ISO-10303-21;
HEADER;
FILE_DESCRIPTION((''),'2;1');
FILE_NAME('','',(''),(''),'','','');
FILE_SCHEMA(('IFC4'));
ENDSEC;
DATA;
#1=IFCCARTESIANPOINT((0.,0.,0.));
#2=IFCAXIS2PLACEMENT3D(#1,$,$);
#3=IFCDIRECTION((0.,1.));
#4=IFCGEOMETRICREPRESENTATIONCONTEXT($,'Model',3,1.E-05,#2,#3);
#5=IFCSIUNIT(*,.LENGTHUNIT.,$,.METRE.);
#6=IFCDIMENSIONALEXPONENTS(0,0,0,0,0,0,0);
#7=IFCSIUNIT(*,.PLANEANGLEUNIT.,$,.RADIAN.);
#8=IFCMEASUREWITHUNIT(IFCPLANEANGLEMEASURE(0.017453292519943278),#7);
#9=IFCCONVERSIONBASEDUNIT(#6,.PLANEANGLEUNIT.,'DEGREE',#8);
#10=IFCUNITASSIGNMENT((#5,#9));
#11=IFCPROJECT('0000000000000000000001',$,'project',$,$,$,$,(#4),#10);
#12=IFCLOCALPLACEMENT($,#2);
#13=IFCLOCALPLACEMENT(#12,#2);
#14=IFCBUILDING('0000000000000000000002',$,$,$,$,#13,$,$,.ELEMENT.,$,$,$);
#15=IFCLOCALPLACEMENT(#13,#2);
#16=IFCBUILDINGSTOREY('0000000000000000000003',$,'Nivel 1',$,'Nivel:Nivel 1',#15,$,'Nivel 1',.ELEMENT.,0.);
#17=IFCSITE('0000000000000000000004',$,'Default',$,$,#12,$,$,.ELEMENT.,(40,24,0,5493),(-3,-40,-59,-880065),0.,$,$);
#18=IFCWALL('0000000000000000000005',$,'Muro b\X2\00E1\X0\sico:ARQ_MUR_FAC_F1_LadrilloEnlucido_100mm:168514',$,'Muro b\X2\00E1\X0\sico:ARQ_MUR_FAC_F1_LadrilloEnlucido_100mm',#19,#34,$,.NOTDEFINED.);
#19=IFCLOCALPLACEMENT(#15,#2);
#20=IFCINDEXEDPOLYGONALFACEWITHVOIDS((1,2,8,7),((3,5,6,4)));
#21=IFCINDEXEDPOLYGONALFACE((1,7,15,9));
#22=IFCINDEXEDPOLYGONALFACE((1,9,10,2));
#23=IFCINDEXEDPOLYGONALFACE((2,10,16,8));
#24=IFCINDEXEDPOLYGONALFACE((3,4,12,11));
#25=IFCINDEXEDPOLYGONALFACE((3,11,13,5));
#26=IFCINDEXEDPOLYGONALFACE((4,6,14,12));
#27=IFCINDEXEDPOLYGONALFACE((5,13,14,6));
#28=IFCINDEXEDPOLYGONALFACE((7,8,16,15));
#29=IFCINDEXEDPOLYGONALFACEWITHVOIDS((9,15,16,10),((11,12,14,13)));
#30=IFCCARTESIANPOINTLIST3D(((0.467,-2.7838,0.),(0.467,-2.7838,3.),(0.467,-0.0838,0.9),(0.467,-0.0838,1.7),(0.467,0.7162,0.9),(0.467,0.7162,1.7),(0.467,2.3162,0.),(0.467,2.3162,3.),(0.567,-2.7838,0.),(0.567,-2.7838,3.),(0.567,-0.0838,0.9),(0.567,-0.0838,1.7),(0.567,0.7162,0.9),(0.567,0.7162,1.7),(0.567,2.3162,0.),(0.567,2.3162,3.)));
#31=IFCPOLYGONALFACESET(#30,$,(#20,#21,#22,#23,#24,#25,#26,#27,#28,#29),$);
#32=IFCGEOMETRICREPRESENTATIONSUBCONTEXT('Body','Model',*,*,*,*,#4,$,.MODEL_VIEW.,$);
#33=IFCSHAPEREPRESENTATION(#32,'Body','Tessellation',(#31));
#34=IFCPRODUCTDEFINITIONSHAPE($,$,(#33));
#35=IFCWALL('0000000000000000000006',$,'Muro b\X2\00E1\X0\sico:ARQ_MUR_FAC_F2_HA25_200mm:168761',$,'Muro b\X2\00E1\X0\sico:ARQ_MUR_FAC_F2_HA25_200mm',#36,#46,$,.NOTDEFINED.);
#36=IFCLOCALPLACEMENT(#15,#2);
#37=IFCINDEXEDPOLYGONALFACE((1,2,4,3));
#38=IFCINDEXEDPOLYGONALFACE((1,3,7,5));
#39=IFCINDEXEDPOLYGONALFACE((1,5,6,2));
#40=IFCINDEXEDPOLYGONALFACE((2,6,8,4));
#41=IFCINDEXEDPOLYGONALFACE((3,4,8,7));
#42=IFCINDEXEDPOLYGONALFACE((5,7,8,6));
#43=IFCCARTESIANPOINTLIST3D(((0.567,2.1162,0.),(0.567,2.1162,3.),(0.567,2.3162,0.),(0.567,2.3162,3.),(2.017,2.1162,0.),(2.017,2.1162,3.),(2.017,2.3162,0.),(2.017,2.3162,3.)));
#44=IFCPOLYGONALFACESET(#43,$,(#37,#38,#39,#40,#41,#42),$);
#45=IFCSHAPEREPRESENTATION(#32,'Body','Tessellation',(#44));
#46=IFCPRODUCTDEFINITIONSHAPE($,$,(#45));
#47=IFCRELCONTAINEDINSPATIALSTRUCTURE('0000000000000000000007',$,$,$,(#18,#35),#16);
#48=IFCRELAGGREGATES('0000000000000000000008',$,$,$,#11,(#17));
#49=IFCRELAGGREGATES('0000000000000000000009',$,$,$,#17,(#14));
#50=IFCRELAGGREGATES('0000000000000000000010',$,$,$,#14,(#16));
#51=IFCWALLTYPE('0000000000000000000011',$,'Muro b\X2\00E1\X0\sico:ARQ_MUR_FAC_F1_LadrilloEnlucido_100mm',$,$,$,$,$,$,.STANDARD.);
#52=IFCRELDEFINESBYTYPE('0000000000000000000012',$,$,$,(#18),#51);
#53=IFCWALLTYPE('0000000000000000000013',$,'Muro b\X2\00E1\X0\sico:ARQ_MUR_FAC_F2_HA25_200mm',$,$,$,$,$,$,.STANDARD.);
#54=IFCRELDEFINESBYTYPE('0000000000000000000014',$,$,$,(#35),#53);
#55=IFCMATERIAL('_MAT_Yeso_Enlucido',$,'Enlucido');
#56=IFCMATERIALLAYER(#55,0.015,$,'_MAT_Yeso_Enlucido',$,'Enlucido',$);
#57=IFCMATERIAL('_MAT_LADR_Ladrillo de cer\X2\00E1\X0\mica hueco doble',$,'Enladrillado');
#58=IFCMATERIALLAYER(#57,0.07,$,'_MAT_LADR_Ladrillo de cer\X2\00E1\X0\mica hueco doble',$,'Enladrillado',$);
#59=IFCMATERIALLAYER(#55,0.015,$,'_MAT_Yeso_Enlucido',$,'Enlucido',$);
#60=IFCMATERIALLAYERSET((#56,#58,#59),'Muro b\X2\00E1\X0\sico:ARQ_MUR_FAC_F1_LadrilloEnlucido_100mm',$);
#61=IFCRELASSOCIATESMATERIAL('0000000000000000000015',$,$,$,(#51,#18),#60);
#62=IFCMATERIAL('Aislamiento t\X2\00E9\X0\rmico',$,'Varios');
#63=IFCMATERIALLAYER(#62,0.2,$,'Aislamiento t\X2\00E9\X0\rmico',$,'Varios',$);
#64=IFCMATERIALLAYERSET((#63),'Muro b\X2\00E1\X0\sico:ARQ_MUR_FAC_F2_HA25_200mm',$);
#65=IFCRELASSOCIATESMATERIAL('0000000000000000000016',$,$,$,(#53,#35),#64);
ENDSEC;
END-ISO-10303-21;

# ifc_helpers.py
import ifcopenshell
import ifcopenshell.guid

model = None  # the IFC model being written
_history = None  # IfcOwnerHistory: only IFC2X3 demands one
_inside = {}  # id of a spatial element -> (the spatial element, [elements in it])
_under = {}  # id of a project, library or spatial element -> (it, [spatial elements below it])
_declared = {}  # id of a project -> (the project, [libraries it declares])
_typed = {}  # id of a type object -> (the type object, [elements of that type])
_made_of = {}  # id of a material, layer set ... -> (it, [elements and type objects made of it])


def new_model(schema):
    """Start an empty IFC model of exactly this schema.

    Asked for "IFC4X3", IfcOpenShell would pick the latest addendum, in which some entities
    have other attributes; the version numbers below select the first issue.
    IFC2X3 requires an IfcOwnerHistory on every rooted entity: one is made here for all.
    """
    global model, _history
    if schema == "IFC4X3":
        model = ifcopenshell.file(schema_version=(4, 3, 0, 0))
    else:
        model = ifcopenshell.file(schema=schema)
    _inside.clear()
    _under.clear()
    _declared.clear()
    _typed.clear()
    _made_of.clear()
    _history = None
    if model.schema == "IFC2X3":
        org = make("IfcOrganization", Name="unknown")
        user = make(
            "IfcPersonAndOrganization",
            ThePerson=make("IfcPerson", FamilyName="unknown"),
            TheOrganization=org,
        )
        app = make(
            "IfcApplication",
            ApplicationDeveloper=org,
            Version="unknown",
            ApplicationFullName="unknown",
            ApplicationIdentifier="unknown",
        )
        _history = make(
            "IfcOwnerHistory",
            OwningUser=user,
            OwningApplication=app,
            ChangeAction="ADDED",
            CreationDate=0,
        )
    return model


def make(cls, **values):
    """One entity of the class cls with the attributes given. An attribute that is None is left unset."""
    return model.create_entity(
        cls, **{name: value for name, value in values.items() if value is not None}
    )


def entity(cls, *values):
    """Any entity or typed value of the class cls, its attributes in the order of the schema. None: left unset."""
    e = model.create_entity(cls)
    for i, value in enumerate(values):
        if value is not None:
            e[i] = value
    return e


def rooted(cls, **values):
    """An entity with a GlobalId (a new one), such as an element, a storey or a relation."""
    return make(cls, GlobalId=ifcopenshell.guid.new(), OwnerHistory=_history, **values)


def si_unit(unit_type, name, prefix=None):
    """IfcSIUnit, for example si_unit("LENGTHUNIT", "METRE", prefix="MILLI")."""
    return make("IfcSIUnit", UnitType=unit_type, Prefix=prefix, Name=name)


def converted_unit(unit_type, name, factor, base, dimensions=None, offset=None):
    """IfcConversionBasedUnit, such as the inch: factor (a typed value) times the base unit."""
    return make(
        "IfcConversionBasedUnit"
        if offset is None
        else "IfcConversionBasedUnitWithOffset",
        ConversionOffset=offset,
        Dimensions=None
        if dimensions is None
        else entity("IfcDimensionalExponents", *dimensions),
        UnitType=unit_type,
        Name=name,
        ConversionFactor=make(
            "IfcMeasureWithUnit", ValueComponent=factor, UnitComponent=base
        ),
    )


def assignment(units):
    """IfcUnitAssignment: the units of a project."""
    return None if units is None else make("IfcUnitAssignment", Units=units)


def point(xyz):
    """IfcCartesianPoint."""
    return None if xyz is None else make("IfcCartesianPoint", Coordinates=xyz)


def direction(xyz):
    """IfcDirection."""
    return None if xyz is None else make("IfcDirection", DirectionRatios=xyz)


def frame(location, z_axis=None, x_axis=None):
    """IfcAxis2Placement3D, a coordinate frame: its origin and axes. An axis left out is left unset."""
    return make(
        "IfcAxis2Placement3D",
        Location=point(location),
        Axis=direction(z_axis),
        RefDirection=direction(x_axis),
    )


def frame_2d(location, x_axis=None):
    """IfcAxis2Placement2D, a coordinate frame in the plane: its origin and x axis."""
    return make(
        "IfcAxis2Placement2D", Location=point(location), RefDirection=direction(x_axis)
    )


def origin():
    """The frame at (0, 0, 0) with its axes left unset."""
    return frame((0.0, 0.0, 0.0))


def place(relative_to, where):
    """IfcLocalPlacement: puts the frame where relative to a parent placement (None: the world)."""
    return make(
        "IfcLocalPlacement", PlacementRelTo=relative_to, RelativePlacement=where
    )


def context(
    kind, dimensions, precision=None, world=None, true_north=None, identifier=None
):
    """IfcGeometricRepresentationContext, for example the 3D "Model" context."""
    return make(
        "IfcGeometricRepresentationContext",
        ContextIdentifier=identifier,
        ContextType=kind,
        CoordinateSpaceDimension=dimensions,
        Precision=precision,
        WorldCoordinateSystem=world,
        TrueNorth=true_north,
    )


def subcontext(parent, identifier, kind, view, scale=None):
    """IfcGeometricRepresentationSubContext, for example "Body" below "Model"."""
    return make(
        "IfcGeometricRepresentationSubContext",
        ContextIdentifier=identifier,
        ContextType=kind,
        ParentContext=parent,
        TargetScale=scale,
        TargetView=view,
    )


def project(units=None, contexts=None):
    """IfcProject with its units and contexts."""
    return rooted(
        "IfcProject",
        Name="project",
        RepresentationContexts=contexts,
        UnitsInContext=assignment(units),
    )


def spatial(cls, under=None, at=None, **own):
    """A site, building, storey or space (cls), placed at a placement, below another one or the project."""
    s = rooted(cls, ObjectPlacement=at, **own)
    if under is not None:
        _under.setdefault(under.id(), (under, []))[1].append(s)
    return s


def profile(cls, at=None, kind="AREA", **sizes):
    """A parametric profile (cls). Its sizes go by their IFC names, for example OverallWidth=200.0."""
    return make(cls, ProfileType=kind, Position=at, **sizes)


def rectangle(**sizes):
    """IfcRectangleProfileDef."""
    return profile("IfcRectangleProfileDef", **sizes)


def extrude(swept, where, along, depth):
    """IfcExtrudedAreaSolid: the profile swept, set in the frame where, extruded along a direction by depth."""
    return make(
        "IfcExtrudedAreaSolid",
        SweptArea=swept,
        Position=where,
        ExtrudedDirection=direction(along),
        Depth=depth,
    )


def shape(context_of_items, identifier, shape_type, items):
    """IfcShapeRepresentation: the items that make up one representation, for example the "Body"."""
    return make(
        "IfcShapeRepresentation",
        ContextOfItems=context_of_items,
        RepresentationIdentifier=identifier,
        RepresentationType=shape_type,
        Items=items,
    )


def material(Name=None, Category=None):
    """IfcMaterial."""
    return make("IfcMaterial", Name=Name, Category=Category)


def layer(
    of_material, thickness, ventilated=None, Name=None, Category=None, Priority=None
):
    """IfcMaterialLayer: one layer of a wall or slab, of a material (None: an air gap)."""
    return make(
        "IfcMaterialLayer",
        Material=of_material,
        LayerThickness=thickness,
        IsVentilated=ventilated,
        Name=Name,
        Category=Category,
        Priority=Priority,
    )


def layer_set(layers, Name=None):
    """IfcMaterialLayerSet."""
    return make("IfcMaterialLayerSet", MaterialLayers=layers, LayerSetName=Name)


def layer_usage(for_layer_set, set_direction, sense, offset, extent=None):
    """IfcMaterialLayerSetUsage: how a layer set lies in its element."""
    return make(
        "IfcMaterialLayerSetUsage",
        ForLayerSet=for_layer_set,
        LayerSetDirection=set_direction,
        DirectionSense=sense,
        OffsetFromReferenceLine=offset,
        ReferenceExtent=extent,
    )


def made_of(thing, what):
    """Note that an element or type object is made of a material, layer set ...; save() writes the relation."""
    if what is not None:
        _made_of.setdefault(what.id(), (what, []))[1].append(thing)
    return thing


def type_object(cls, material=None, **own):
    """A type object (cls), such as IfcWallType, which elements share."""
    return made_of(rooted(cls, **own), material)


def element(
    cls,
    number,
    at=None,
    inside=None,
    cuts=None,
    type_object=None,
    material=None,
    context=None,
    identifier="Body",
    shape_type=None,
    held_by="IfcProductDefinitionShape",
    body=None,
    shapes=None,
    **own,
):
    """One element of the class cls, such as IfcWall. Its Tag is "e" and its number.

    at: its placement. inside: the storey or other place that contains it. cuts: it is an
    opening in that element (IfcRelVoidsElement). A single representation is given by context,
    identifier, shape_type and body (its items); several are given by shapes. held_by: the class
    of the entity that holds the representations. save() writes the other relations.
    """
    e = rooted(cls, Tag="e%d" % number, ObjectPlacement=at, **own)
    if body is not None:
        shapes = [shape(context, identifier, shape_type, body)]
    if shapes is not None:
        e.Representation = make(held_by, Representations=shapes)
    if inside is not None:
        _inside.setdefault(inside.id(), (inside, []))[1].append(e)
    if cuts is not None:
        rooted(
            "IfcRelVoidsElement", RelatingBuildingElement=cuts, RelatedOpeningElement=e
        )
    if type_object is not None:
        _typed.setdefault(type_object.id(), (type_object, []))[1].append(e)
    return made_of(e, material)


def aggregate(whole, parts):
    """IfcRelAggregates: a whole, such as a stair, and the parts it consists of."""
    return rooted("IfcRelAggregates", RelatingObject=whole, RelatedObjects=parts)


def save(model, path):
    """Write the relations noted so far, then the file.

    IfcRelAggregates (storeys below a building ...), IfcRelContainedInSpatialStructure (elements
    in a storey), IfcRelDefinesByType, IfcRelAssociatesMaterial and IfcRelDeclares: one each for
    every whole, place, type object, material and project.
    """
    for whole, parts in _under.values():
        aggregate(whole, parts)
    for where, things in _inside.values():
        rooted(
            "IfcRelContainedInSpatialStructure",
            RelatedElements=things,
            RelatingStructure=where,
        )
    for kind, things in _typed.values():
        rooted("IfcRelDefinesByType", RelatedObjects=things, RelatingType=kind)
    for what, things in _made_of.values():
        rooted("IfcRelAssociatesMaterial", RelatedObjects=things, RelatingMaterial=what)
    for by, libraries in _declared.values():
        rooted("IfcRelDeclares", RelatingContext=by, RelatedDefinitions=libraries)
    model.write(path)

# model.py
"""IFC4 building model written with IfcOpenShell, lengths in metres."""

from ifc_helpers import new_model, entity, si_unit, converted_unit, direction, frame, frame_2d, origin, place, context, subcontext, project, spatial, rectangle, extrude, material, layer, layer_set, layer_usage, type_object, element, save


model = new_model("IFC4")

# Units and contexts
model_context = context("Model", 3, precision=1e-05, world=origin(), true_north=direction((0.0, 1.0)))
body_context = subcontext(model_context, "Body", "Model", "MODEL_VIEW")
ifc_project = project(units=[si_unit("LENGTHUNIT", "METRE"), converted_unit("PLANEANGLEUNIT", "DEGREE", entity("IfcPlaneAngleMeasure", 0.017453292519943278), si_unit("PLANEANGLEUNIT", "RADIAN"), dimensions=[0, 0, 0, 0, 0, 0, 0])], contexts=[model_context])

# Site, building, storey
site_placement = place(None, origin())
site = spatial("IfcSite", under=ifc_project, at=site_placement, Name="Default", CompositionType="ELEMENT", RefLatitude=(40, 24, 0, 5493), RefLongitude=(-3, -40, -59, -880065), RefElevation=0.0)
building_placement = place(site_placement, origin())
building = spatial("IfcBuilding", under=site, at=building_placement, CompositionType="ELEMENT")
storey_placement = place(building_placement, origin())
storey = spatial("IfcBuildingStorey", under=building, at=storey_placement, Name="Nivel 1", ObjectType="Nivel:Nivel 1", LongName="Nivel 1", CompositionType="ELEMENT", Elevation=0.0)

# Wall, opening
ifc_material_1 = material(Name="_MAT_Yeso_Enlucido", Category="Enlucido")
ifc_layer_1 = layer(ifc_material_1, 0.015, Name="_MAT_Yeso_Enlucido", Category="Enlucido")
ifc_material_2 = material(Name="_MAT_LADR_Ladrillo de cerámica hueco doble", Category="Enladrillado")
ifc_layer_2 = layer(ifc_material_2, 0.07, Name="_MAT_LADR_Ladrillo de cerámica hueco doble", Category="Enladrillado")
ifc_layer_3 = layer(ifc_material_1, 0.015, Name="_MAT_Yeso_Enlucido", Category="Enlucido")
ifc_layer_set_1 = layer_set([ifc_layer_1, ifc_layer_2, ifc_layer_3], Name="Muro básico:ARQ_MUR_FAC_F1_LadrilloEnlucido_100mm")
ifc_layer_usage_1 = layer_usage(ifc_layer_set_1, "AXIS2", "NEGATIVE", 0.05)
wall_type_1 = type_object("IfcWallType", Name="Muro básico:ARQ_MUR_FAC_F1_LadrilloEnlucido_100mm", PredefinedType="STANDARD", material=ifc_layer_set_1)
wall_1_placement = place(storey_placement, frame((0.517, -2.7838, 0.0), z_axis=(0.0, 0.0, 1.0), x_axis=(0.0, 1.0, 0.0)))
wall_1 = element("IfcWall", 1, at=wall_1_placement, inside=storey, type_object=wall_type_1, material=ifc_layer_usage_1, Name="Muro básico:ARQ_MUR_FAC_F1_LadrilloEnlucido_100mm:168514", ObjectType="Muro básico:ARQ_MUR_FAC_F1_LadrilloEnlucido_100mm", PredefinedType="NOTDEFINED", context=body_context, shape_type="SweptSolid", body=[
    extrude(rectangle(XDim=5.1, YDim=0.1, at=frame_2d((2.55, 0.0), x_axis=(-1.0, 0.0))), origin(), (0.0, 0.0, 1.0), 3.0),
])
opening_placement = place(wall_1_placement, frame((2.7, -0.05, 0.9)))
element("IfcOpeningElement", 2, at=opening_placement, cuts=wall_1, PredefinedType="OPENING", context=body_context, shape_type="SweptSolid", body=[
    extrude(rectangle(XDim=0.8, YDim=0.8, at=frame_2d((0.4, 0.4), x_axis=(1.0, 0.0))), frame((0.0, 0.0, 0.0), z_axis=(0.0, 1.0, 0.0), x_axis=(0.0, 0.0, 1.0)), (0.0, 0.0, 1.0), 0.1),
])

# Wall
ifc_material_3 = material(Name="Aislamiento térmico", Category="Varios")
ifc_layer_4 = layer(ifc_material_3, 0.2, Name="Aislamiento térmico", Category="Varios")
ifc_layer_set_2 = layer_set([ifc_layer_4], Name="Muro básico:ARQ_MUR_FAC_F2_HA25_200mm")
ifc_layer_usage_2 = layer_usage(ifc_layer_set_2, "AXIS2", "NEGATIVE", 0.1)
wall_type_2 = type_object("IfcWallType", Name="Muro básico:ARQ_MUR_FAC_F2_HA25_200mm", PredefinedType="STANDARD", material=ifc_layer_set_2)
wall_2_placement = place(storey_placement, frame((0.567, 2.2162, 0.0)))
element("IfcWall", 3, at=wall_2_placement, inside=storey, type_object=wall_type_2, material=ifc_layer_usage_2, Name="Muro básico:ARQ_MUR_FAC_F2_HA25_200mm:168761", ObjectType="Muro básico:ARQ_MUR_FAC_F2_HA25_200mm", PredefinedType="NOTDEFINED", context=body_context, shape_type="SweptSolid", body=[
    extrude(rectangle(XDim=1.45, YDim=0.2, at=frame_2d((0.725, 0.0), x_axis=(-1.0, 0.0))), origin(), (0.0, 0.0, 1.0), 3.0),
])

save(model, "model.ifc")
